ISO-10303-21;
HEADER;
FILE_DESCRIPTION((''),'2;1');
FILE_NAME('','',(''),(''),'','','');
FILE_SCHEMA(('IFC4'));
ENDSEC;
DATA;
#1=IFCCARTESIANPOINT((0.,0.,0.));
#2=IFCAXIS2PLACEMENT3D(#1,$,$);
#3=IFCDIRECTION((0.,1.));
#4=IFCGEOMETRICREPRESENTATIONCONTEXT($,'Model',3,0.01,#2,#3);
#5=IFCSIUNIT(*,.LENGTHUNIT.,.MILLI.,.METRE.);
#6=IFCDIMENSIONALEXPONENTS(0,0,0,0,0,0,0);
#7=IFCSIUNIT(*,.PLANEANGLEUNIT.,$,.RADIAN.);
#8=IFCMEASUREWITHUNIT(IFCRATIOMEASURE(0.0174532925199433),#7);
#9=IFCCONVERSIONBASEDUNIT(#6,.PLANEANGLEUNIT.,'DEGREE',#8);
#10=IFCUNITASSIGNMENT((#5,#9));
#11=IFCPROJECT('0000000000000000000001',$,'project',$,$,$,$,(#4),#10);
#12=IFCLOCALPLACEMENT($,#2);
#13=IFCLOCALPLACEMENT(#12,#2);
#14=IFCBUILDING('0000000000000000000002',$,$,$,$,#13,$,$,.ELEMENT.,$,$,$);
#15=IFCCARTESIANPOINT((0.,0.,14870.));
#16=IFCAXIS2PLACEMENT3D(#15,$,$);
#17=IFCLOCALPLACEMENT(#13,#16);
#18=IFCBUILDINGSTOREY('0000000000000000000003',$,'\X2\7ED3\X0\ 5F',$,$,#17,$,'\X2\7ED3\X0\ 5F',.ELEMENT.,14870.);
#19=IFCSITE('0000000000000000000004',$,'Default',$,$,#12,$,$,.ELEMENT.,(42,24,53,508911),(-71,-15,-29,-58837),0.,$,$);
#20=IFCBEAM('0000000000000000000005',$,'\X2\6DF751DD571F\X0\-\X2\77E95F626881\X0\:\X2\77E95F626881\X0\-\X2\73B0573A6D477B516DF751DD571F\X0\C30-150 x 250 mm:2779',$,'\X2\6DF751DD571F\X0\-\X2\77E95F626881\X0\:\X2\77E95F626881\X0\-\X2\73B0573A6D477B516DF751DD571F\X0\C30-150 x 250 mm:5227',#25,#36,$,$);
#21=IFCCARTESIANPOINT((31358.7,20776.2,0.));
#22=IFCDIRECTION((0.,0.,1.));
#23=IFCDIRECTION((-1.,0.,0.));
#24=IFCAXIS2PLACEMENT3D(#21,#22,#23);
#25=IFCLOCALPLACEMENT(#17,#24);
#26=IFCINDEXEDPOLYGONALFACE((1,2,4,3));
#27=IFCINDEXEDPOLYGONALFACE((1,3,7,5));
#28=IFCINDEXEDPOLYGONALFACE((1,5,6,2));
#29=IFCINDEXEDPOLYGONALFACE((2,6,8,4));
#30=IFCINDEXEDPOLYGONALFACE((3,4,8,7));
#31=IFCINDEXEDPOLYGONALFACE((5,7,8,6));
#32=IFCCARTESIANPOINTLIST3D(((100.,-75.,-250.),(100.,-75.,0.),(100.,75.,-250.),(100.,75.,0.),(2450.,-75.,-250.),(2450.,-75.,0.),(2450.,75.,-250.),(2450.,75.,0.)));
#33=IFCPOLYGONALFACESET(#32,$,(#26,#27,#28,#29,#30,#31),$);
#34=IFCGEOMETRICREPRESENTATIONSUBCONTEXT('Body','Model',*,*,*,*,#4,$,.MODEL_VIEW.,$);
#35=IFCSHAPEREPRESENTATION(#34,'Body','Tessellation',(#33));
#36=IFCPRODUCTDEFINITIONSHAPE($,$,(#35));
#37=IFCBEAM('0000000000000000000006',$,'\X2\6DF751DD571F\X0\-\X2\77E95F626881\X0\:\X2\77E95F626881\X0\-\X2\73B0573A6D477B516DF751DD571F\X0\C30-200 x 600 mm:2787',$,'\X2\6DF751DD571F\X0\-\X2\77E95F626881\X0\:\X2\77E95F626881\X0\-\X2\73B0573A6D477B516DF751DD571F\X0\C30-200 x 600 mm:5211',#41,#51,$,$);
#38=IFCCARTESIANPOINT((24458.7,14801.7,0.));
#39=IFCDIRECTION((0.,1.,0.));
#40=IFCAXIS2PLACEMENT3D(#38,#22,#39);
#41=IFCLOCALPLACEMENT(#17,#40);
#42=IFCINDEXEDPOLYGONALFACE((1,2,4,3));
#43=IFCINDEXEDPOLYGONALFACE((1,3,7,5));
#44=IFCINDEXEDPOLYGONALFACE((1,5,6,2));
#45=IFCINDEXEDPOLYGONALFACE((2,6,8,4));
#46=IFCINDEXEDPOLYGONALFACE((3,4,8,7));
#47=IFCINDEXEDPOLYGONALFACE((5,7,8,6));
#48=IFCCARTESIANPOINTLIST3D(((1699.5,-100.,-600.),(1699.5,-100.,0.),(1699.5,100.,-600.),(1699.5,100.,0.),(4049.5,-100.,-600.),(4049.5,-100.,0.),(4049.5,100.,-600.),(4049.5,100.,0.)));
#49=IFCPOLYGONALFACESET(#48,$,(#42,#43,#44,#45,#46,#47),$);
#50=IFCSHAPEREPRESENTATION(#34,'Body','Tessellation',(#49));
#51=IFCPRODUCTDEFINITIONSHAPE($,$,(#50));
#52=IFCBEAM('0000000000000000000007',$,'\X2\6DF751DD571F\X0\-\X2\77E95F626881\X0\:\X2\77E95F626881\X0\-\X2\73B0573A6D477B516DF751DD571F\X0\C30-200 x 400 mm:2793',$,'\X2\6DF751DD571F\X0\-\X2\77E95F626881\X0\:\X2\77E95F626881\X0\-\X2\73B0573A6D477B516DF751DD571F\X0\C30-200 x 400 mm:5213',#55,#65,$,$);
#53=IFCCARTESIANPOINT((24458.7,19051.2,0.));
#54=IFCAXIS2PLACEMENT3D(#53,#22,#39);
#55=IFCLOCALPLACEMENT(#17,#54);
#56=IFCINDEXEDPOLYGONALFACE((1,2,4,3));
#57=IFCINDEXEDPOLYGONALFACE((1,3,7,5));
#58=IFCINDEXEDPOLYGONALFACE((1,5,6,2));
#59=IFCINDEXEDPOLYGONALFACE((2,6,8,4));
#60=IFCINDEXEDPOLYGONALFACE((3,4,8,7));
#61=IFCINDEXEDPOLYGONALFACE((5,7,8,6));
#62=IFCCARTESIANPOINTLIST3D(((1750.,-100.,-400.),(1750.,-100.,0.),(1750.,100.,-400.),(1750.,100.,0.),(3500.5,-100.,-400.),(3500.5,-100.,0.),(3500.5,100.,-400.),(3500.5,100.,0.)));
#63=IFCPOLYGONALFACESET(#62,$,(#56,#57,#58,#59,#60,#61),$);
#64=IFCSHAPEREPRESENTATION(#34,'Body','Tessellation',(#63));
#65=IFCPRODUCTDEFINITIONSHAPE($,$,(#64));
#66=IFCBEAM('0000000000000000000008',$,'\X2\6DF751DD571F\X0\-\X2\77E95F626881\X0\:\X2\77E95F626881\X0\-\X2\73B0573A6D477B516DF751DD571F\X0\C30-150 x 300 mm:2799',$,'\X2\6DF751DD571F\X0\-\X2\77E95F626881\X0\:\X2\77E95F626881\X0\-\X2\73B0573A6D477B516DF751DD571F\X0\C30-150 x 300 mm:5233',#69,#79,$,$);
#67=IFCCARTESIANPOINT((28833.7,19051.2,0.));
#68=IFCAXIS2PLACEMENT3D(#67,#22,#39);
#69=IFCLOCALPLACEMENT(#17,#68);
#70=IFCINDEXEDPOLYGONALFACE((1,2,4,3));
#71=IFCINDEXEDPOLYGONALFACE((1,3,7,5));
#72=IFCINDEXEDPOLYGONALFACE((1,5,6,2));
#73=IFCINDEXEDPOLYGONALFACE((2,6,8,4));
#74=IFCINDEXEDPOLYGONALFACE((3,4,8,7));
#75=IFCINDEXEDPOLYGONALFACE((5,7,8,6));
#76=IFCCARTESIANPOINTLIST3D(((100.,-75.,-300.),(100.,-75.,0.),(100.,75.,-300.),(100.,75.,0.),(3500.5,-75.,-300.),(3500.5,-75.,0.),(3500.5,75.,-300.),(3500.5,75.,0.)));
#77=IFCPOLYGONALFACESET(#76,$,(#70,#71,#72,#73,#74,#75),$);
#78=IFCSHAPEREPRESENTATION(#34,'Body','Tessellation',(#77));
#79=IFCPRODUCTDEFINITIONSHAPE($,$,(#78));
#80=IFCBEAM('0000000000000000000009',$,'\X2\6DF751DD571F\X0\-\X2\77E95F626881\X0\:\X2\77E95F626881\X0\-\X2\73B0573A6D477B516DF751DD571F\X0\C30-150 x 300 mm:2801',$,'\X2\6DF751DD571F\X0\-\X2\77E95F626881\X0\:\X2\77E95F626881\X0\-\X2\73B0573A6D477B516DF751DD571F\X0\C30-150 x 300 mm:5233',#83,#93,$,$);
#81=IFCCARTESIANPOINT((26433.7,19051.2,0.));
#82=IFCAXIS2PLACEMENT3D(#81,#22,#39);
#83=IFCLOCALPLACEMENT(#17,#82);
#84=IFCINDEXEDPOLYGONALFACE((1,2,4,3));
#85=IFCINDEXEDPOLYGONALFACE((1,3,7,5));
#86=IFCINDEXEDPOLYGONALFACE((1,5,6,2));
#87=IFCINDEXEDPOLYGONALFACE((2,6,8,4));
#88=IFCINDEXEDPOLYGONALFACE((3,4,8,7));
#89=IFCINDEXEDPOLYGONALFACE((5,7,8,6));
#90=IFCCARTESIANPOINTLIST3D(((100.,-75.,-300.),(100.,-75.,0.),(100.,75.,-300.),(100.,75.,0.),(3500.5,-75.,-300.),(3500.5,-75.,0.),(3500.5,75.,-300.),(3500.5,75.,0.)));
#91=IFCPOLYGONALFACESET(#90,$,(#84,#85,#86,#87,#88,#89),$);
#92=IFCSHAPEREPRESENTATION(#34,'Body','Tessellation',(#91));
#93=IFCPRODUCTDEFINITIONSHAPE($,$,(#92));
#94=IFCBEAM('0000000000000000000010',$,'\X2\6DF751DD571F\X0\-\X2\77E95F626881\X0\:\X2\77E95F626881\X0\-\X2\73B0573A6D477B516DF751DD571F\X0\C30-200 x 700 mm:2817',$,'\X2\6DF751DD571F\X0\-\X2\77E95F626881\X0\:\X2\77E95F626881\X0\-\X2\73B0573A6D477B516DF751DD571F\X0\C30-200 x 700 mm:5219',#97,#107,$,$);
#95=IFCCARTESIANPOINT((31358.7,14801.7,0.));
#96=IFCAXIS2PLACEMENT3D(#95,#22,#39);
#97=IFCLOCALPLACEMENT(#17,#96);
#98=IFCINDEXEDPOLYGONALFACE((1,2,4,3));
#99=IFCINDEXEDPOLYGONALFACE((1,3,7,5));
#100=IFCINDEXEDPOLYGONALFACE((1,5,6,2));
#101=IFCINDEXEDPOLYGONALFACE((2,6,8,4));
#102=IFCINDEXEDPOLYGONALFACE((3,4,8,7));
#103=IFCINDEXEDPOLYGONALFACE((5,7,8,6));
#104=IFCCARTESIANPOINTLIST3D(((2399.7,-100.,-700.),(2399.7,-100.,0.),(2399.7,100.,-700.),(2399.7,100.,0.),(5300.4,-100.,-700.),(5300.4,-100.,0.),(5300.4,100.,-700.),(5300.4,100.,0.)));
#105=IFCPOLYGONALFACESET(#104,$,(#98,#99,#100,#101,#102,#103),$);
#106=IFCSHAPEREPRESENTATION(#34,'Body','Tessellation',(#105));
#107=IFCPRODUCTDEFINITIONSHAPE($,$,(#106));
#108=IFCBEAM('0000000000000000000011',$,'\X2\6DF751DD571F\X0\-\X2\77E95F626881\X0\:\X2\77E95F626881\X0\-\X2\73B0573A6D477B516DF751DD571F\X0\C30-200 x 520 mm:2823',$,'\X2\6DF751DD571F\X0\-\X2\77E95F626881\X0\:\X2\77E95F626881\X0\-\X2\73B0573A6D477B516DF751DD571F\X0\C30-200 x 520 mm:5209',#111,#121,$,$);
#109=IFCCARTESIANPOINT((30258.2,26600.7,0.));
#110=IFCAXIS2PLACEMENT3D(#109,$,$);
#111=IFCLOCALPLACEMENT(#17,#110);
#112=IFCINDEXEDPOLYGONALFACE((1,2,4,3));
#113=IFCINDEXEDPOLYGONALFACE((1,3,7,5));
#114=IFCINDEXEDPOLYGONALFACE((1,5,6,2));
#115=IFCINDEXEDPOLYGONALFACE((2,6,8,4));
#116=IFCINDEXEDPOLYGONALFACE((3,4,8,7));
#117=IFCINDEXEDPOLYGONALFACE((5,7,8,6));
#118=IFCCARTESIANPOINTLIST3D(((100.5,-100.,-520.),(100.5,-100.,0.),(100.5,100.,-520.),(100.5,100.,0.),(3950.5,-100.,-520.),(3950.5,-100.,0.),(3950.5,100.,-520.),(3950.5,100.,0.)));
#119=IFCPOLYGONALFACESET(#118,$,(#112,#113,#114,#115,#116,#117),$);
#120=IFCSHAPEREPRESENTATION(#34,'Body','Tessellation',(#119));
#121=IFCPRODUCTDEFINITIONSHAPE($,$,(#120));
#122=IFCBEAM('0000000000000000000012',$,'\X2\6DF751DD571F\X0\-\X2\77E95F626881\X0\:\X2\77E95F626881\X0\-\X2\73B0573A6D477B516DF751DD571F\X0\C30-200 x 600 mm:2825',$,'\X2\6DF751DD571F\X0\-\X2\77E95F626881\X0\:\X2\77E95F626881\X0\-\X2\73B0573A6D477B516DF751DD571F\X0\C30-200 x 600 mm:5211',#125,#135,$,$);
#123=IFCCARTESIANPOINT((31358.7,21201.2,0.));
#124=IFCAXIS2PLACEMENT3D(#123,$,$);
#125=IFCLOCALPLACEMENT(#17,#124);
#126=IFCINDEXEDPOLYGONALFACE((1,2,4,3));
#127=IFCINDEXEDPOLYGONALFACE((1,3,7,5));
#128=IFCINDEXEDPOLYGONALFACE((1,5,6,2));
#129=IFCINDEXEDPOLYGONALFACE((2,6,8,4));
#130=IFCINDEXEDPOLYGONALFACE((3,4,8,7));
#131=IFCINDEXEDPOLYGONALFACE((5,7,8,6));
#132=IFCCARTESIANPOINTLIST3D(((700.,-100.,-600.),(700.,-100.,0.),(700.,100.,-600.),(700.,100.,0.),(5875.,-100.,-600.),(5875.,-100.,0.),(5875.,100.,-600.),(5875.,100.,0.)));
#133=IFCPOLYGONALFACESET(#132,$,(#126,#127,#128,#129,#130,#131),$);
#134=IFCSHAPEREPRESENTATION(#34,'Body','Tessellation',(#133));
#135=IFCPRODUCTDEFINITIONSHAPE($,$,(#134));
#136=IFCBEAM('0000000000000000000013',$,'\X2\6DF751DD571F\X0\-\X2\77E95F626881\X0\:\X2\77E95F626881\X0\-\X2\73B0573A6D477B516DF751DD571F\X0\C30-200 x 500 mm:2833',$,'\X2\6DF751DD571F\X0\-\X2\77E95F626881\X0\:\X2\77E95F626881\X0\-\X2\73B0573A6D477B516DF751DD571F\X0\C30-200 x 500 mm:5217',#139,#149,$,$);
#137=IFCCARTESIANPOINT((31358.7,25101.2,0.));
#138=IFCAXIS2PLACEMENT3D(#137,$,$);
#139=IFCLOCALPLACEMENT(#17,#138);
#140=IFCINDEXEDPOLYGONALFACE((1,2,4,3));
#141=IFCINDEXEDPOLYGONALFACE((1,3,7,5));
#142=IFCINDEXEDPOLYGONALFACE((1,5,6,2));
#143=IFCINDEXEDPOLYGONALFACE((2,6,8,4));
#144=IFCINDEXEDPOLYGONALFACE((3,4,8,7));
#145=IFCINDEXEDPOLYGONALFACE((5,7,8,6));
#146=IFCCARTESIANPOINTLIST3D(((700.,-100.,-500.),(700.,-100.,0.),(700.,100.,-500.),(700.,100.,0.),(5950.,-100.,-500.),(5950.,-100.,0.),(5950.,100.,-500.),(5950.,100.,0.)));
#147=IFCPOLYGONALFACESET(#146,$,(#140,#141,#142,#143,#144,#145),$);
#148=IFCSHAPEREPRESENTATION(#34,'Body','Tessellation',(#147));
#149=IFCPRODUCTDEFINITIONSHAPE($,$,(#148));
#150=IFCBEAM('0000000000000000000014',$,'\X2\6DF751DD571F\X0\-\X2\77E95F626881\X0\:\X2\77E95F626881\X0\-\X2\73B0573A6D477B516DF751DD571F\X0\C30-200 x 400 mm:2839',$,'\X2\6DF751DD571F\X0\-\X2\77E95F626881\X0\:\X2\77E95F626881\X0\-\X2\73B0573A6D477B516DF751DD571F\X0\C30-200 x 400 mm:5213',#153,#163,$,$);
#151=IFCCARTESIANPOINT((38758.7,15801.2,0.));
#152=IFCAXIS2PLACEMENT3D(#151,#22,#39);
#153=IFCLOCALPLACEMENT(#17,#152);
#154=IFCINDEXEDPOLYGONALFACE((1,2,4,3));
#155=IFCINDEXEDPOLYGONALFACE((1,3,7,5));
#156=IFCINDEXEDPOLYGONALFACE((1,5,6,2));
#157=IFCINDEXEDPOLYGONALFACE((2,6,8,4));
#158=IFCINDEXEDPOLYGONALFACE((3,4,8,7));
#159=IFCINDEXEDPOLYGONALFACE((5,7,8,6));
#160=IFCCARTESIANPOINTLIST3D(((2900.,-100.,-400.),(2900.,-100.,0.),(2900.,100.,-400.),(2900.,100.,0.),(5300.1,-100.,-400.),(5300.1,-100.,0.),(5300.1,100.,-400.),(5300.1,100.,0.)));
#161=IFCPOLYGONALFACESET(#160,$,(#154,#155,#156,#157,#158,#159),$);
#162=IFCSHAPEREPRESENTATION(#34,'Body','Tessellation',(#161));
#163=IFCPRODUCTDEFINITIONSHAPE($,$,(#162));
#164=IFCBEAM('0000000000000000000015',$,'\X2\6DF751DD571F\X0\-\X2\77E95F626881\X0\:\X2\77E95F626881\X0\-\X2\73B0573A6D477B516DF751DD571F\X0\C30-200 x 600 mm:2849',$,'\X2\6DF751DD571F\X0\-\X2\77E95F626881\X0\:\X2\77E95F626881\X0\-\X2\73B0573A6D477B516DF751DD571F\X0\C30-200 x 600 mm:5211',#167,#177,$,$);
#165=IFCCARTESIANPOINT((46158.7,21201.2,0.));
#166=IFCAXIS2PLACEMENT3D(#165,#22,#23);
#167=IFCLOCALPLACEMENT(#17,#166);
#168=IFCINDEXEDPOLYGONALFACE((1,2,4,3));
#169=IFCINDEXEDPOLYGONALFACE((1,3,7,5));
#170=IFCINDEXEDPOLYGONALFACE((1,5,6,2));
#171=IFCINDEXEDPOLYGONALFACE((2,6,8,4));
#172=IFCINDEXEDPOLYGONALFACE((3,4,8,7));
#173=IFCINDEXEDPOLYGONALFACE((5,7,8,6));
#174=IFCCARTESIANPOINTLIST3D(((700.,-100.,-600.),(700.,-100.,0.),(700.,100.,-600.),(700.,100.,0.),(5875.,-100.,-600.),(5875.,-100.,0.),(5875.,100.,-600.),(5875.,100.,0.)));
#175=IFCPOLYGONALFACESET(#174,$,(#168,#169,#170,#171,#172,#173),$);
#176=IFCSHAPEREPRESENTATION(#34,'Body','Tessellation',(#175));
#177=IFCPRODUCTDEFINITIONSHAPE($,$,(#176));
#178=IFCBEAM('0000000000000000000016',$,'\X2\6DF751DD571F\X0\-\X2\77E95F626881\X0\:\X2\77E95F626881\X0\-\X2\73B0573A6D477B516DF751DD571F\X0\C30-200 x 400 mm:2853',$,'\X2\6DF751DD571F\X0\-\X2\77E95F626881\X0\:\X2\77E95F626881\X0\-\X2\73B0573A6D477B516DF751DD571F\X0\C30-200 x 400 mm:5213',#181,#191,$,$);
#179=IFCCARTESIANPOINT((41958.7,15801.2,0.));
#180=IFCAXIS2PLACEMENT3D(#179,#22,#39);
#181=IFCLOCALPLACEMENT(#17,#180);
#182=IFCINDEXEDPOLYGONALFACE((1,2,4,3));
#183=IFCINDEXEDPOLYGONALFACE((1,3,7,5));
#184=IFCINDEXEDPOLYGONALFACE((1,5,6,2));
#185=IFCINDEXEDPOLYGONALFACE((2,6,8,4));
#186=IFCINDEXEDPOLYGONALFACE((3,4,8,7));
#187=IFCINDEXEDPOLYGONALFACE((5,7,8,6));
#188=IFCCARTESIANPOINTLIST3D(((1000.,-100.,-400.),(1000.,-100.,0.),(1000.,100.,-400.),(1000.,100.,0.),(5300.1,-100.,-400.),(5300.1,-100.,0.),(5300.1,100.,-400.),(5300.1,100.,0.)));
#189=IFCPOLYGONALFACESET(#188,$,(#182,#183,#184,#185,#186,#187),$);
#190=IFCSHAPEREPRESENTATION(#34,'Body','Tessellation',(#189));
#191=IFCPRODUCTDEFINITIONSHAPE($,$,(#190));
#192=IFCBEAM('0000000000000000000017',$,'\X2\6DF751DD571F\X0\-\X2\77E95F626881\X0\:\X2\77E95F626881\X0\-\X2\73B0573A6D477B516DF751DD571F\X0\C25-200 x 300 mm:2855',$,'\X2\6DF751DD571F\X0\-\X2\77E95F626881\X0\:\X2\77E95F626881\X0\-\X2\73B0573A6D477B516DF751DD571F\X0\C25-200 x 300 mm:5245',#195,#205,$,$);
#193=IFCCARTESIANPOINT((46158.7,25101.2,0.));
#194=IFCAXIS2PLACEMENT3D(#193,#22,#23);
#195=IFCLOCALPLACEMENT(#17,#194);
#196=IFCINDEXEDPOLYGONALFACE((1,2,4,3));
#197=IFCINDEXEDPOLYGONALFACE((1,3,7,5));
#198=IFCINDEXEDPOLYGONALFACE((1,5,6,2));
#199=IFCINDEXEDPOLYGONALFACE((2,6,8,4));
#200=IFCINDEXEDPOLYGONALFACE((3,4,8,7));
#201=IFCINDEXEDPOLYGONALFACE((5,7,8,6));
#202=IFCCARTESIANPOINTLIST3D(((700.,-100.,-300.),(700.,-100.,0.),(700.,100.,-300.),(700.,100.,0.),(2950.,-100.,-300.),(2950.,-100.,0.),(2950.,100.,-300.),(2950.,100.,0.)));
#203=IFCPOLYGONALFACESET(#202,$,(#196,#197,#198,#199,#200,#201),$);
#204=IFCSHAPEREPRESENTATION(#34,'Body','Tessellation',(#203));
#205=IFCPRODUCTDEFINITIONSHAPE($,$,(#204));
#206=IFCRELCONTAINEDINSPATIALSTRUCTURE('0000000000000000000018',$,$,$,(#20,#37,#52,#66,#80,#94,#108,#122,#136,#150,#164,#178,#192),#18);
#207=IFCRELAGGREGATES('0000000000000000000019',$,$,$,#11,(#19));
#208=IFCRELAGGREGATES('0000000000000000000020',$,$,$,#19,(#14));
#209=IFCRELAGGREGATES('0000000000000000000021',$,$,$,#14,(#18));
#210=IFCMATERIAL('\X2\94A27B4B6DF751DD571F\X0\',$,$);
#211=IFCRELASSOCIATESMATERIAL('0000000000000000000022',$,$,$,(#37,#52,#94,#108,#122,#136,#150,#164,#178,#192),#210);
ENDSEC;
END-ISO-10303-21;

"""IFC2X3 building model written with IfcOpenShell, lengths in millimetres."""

from ifc_helpers import new_model, entity, si_unit, converted_unit, direction, frame, frame_2d, origin, origin_2d_with_axis, place, context, subcontext, project, spatial, rectangle, extrude, material, element, save


model = new_model("IFC2X3")

# Units and contexts
model_context = context("Model", 3, precision=0.01, world=origin(), true_north=direction((0.0, 1.0)))
body_context = subcontext(model_context, "Body", "Model", "MODEL_VIEW")
ifc_project = project(units=[si_unit("LENGTHUNIT", "METRE", prefix="MILLI"), converted_unit("PLANEANGLEUNIT", "DEGREE", entity("IfcRatioMeasure", 0.0174532925199433), si_unit("PLANEANGLEUNIT", "RADIAN"), dimensions=[0, 0, 0, 0, 0, 0, 0])], contexts=[model_context])

# Site, building, storey
site_placement = place(None, origin())
site = spatial("IfcSite", under=ifc_project, at=site_placement, Name="Default", CompositionType="ELEMENT", RefLatitude=(42, 24, 53, 508911), RefLongitude=(-71, -15, -29, -58837), RefElevation=0.0)
building_placement = place(site_placement, origin())
building = spatial("IfcBuilding", under=site, at=building_placement, CompositionType="ELEMENT")
storey_placement = place(building_placement, frame((0.0, 0.0, 14870.0)))
storey = spatial("IfcBuildingStorey", under=building, at=storey_placement, Name="结 5F", LongName="结 5F", CompositionType="ELEMENT", Elevation=14870.0)

# Beams
beam_1_placement = place(storey_placement, frame((31358.7, 20776.2, 0.0), z_axis=(0.0, 0.0, 1.0), x_axis=(-1.0, 0.0, 0.0)))
element("IfcBeam", 1, at=beam_1_placement, inside=storey, Name="混凝土-矩形梁:矩形梁-现场浇筑混凝土C30-150 x 250 mm:2779", ObjectType="混凝土-矩形梁:矩形梁-现场浇筑混凝土C30-150 x 250 mm:5227", context=body_context, shape_type="SweptSolid", body=[
    extrude(rectangle(XDim=250.0, YDim=150.0, at=frame_2d((0.0, 0.0), x_axis=(1.0, 0.0))), frame((100.0, 0.0, -125.0), z_axis=(1.0, 0.0, 0.0), x_axis=(0.0, 0.0, -1.0)), (0.0, 0.0, 1.0), 2350.0),
])
ifc_material = material(Name="钢筋混凝土")
beam_2_placement = place(storey_placement, frame((24458.7, 14801.7, 0.0), z_axis=(0.0, 0.0, 1.0), x_axis=(0.0, 1.0, 0.0)))
element("IfcBeam", 2, at=beam_2_placement, inside=storey, material=ifc_material, Name="混凝土-矩形梁:矩形梁-现场浇筑混凝土C30-200 x 600 mm:2787", ObjectType="混凝土-矩形梁:矩形梁-现场浇筑混凝土C30-200 x 600 mm:5211", context=body_context, shape_type="SweptSolid", body=[
    extrude(rectangle(XDim=600.0, YDim=200.0, at=frame_2d((0.0, 0.0), x_axis=(1.0, 0.0))), frame((1699.5, 0.0, -300.0), z_axis=(1.0, 0.0, 0.0), x_axis=(0.0, 0.0, -1.0)), (0.0, 0.0, 1.0), 2350.0),
])
beam_3_placement = place(storey_placement, frame((24458.7, 19051.2, 0.0), z_axis=(0.0, 0.0, 1.0), x_axis=(0.0, 1.0, 0.0)))
element("IfcBeam", 3, at=beam_3_placement, inside=storey, material=ifc_material, Name="混凝土-矩形梁:矩形梁-现场浇筑混凝土C30-200 x 400 mm:2793", ObjectType="混凝土-矩形梁:矩形梁-现场浇筑混凝土C30-200 x 400 mm:5213", context=body_context, shape_type="SweptSolid", body=[
    extrude(rectangle(XDim=400.0, YDim=200.0, at=frame_2d((0.0, 0.0), x_axis=(1.0, 0.0))), frame((1750.0, 0.0, -200.0), z_axis=(1.0, 0.0, 0.0), x_axis=(0.0, 0.0, -1.0)), (0.0, 0.0, 1.0), 1750.5),
])
beam_4_placement = place(storey_placement, frame((28833.7, 19051.2, 0.0), z_axis=(0.0, 0.0, 1.0), x_axis=(0.0, 1.0, 0.0)))
element("IfcBeam", 4, at=beam_4_placement, inside=storey, Name="混凝土-矩形梁:矩形梁-现场浇筑混凝土C30-150 x 300 mm:2799", ObjectType="混凝土-矩形梁:矩形梁-现场浇筑混凝土C30-150 x 300 mm:5233", context=body_context, shape_type="SweptSolid", body=[
    extrude(rectangle(XDim=300.0, YDim=150.0, at=frame_2d((0.0, 0.0), x_axis=(1.0, 0.0))), frame((100.0, 0.0, -150.0), z_axis=(1.0, 0.0, 0.0), x_axis=(0.0, 0.0, -1.0)), (0.0, 0.0, 1.0), 3400.5),
])
beam_5_placement = place(storey_placement, frame((26433.7, 19051.2, 0.0), z_axis=(0.0, 0.0, 1.0), x_axis=(0.0, 1.0, 0.0)))
element("IfcBeam", 5, at=beam_5_placement, inside=storey, Name="混凝土-矩形梁:矩形梁-现场浇筑混凝土C30-150 x 300 mm:2801", ObjectType="混凝土-矩形梁:矩形梁-现场浇筑混凝土C30-150 x 300 mm:5233", context=body_context, shape_type="SweptSolid", body=[
    extrude(rectangle(XDim=300.0, YDim=150.0, at=frame_2d((0.0, 0.0), x_axis=(1.0, 0.0))), frame((100.0, 0.0, -150.0), z_axis=(1.0, 0.0, 0.0), x_axis=(0.0, 0.0, -1.0)), (0.0, 0.0, 1.0), 3400.5),
])
beam_6_placement = place(storey_placement, frame((31358.7, 14801.7, 0.0), z_axis=(0.0, 0.0, 1.0), x_axis=(0.0, 1.0, 0.0)))
element("IfcBeam", 6, at=beam_6_placement, inside=storey, material=ifc_material, Name="混凝土-矩形梁:矩形梁-现场浇筑混凝土C30-200 x 700 mm:2817", ObjectType="混凝土-矩形梁:矩形梁-现场浇筑混凝土C30-200 x 700 mm:5219", context=body_context, shape_type="SweptSolid", body=[
    extrude(rectangle(XDim=700.0, YDim=200.0, at=frame_2d((0.0, 0.0), x_axis=(1.0, 0.0))), frame((2399.7, 0.0, -350.0), z_axis=(1.0, 0.0, 0.0), x_axis=(0.0, 0.0, -1.0)), (0.0, 0.0, 1.0), 2900.7),
])
beam_7_placement = place(storey_placement, frame((30258.2, 26600.7, 0.0)))
element("IfcBeam", 7, at=beam_7_placement, inside=storey, material=ifc_material, Name="混凝土-矩形梁:矩形梁-现场浇筑混凝土C30-200 x 520 mm:2823", ObjectType="混凝土-矩形梁:矩形梁-现场浇筑混凝土C30-200 x 520 mm:5209", context=body_context, shape_type="SweptSolid", body=[
    extrude(rectangle(XDim=520.0, YDim=200.0, at=frame_2d((0.0, 0.0), x_axis=(1.0, 0.0))), frame((100.5, 0.0, -260.0), z_axis=(1.0, 0.0, 0.0), x_axis=(0.0, 0.0, -1.0)), (0.0, 0.0, 1.0), 3850.0),
])
beam_8_placement = place(storey_placement, frame((31358.7, 21201.2, 0.0)))
element("IfcBeam", 8, at=beam_8_placement, inside=storey, material=ifc_material, Name="混凝土-矩形梁:矩形梁-现场浇筑混凝土C30-200 x 600 mm:2825", ObjectType="混凝土-矩形梁:矩形梁-现场浇筑混凝土C30-200 x 600 mm:5211", context=body_context, shape_type="SweptSolid", body=[
    extrude(rectangle(XDim=600.0, YDim=200.0, at=frame_2d((0.0, 0.0), x_axis=(1.0, 0.0))), frame((700.0, 0.0, -300.0), z_axis=(1.0, 0.0, 0.0), x_axis=(0.0, 0.0, -1.0)), (0.0, 0.0, 1.0), 5175.0),
])
beam_9_placement = place(storey_placement, frame((31358.7, 25101.2, 0.0)))
element("IfcBeam", 9, at=beam_9_placement, inside=storey, material=ifc_material, Name="混凝土-矩形梁:矩形梁-现场浇筑混凝土C30-200 x 500 mm:2833", ObjectType="混凝土-矩形梁:矩形梁-现场浇筑混凝土C30-200 x 500 mm:5217", context=body_context, shape_type="SweptSolid", body=[
    extrude(rectangle(XDim=500.0, YDim=200.0, at=frame_2d((0.0, 0.0), x_axis=(1.0, 0.0))), frame((700.0, 0.0, -250.0), z_axis=(1.0, 0.0, 0.0), x_axis=(0.0, 0.0, -1.0)), (0.0, 0.0, 1.0), 5250.0),
])
beam_10_placement = place(storey_placement, frame((38758.7, 15801.2, 0.0), z_axis=(0.0, 0.0, 1.0), x_axis=(0.0, 1.0, 0.0)))
element("IfcBeam", 10, at=beam_10_placement, inside=storey, material=ifc_material, Name="混凝土-矩形梁:矩形梁-现场浇筑混凝土C30-200 x 400 mm:2839", ObjectType="混凝土-矩形梁:矩形梁-现场浇筑混凝土C30-200 x 400 mm:5213", context=body_context, shape_type="SweptSolid", body=[
    extrude(rectangle(XDim=400.0, YDim=200.0, at=frame_2d((0.0, 0.0), x_axis=(1.0, 0.0))), frame((2900.0, 0.0, -200.0), z_axis=(1.0, 0.0, 0.0), x_axis=(0.0, 0.0, -1.0)), (0.0, 0.0, 1.0), 2400.0),
])
beam_11_placement = place(storey_placement, frame((46158.7, 21201.2, 0.0), z_axis=(0.0, 0.0, 1.0), x_axis=(-1.0, 0.0, 0.0)))
element("IfcBeam", 11, at=beam_11_placement, inside=storey, material=ifc_material, Name="混凝土-矩形梁:矩形梁-现场浇筑混凝土C30-200 x 600 mm:2849", ObjectType="混凝土-矩形梁:矩形梁-现场浇筑混凝土C30-200 x 600 mm:5211", context=body_context, shape_type="SweptSolid", body=[
    extrude(rectangle(XDim=600.0, YDim=200.0, at=frame_2d((0.0, 0.0), x_axis=(1.0, 0.0))), frame((700.0, 0.0, -300.0), z_axis=(1.0, 0.0, 0.0), x_axis=(0.0, 0.0, -1.0)), (0.0, 0.0, 1.0), 5175.0),
])
beam_12_placement = place(storey_placement, frame((41958.7, 15801.2, 0.0), z_axis=(0.0, 0.0, 1.0), x_axis=(0.0, 1.0, 0.0)))
element("IfcBeam", 12, at=beam_12_placement, inside=storey, material=ifc_material, Name="混凝土-矩形梁:矩形梁-现场浇筑混凝土C30-200 x 400 mm:2853", ObjectType="混凝土-矩形梁:矩形梁-现场浇筑混凝土C30-200 x 400 mm:5213", context=body_context, shape_type="SweptSolid", body=[
    extrude(rectangle(XDim=400.0, YDim=200.0, at=origin_2d_with_axis()), frame((1000.0, 0.0, -200.0), z_axis=(1.0, 0.0, 0.0), x_axis=(0.0, 0.0, -1.0)), (0.0, 0.0, 1.0), 4300.0),
])
beam_13_placement = place(storey_placement, frame((46158.7, 25101.2, 0.0), z_axis=(0.0, 0.0, 1.0), x_axis=(-1.0, 0.0, 0.0)))
element("IfcBeam", 13, at=beam_13_placement, inside=storey, material=ifc_material, Name="混凝土-矩形梁:矩形梁-现场浇筑混凝土C25-200 x 300 mm:2855", ObjectType="混凝土-矩形梁:矩形梁-现场浇筑混凝土C25-200 x 300 mm:5245", context=body_context, shape_type="SweptSolid", body=[
    extrude(rectangle(XDim=300.0, YDim=200.0, at=frame_2d((0.0, 0.0), x_axis=(1.0, 0.0))), frame((700.0, 0.0, -150.0), z_axis=(1.0, 0.0, 0.0), x_axis=(0.0, 0.0, -1.0)), (0.0, 0.0, 1.0), 2250.0),
])

save(model, "model.ifc")
